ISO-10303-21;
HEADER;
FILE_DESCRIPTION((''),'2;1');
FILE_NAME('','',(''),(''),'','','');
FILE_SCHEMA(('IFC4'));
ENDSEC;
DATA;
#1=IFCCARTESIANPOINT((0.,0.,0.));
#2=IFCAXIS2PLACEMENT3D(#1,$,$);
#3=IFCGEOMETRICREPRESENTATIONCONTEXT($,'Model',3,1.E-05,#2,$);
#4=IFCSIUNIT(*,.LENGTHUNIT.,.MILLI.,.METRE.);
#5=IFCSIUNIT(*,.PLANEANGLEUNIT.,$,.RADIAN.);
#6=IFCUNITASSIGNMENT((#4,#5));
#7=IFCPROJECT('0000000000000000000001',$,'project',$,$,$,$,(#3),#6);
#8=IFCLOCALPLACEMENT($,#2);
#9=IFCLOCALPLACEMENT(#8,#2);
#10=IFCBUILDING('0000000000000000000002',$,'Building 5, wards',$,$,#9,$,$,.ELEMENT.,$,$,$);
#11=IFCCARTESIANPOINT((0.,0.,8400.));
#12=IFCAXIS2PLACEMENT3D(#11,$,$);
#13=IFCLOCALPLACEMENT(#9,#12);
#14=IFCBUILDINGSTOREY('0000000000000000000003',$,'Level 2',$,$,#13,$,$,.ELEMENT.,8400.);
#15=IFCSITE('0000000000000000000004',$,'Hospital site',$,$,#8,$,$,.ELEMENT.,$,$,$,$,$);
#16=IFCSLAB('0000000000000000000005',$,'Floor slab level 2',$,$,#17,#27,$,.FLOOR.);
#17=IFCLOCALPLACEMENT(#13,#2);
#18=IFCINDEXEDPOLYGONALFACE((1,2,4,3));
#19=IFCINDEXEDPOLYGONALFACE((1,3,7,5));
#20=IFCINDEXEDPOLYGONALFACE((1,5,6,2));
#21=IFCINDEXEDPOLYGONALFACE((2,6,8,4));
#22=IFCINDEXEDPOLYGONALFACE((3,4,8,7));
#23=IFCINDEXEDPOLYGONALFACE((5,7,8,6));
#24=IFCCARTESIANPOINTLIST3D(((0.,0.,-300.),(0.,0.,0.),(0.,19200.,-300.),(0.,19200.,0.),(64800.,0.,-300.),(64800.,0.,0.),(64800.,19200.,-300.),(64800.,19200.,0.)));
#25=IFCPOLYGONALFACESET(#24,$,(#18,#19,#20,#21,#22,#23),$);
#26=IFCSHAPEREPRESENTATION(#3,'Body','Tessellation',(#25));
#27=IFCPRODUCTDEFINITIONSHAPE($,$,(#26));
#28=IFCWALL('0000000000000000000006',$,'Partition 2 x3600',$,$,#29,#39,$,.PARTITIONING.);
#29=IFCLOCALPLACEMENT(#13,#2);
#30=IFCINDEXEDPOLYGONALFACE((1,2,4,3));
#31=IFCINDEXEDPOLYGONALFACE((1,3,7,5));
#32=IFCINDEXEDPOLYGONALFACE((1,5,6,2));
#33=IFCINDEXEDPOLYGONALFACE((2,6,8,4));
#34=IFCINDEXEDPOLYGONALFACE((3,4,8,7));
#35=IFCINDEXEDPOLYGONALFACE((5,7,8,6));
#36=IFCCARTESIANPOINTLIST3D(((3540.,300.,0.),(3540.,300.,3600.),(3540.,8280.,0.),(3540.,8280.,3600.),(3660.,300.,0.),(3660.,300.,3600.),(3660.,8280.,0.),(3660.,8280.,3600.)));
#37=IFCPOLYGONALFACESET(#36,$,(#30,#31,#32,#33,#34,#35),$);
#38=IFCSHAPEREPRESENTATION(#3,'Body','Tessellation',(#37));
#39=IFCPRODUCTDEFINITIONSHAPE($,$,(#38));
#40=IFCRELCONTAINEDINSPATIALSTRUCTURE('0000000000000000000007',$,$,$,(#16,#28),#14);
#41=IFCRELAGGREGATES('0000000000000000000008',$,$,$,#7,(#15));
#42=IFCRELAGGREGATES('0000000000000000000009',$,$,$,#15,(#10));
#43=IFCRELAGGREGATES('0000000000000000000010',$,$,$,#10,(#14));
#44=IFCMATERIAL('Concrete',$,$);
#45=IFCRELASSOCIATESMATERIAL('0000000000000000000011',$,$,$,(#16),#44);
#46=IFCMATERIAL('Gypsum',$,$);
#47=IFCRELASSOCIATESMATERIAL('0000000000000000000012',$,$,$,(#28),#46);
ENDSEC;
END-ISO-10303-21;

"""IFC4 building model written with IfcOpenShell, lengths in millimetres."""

from ifc_helpers import new_model, si_unit, frame, frame_2d, origin, place, context, project, spatial, rectangle, extrude, material, element, save


model = new_model("IFC4")

# Units and contexts
model_context = context("Model", 3, precision=1e-05, world=origin())
ifc_project = project(units=[si_unit("LENGTHUNIT", "METRE", prefix="MILLI"), si_unit("PLANEANGLEUNIT", "RADIAN")], contexts=[model_context])

# Site, building, storey
site_placement = place(None, origin())
site = spatial("IfcSite", under=ifc_project, at=site_placement, Name="Hospital site", CompositionType="ELEMENT")
building_placement = place(site_placement, origin())
building = spatial("IfcBuilding", under=site, at=building_placement, Name="Building 5, wards", CompositionType="ELEMENT")
storey_placement = place(building_placement, frame((0.0, 0.0, 8400.0)))
storey = spatial("IfcBuildingStorey", under=building, at=storey_placement, Name="Level 2", CompositionType="ELEMENT", Elevation=8400.0)

# Slab
ifc_material_1 = material(Name="Concrete")
slab_placement = place(storey_placement, origin())
element("IfcSlab", 1, at=slab_placement, inside=storey, material=ifc_material_1, Name="Floor slab level 2", PredefinedType="FLOOR", context=model_context, shape_type="SweptSolid", body=[
    extrude(rectangle(XDim=64800.0, YDim=19200.0, at=frame_2d((32400.0, 9600.0))), frame((0.0, 0.0, -300.0)), (0.0, 0.0, 1.0), 300.0),
])

# Wall
ifc_material_2 = material(Name="Gypsum")
wall_1_placement = place(storey_placement, frame((3660.0, 300.0, 0.0), x_axis=(0.0, 1.0, 0.0)))
element("IfcWall", 2, at=wall_1_placement, inside=storey, material=ifc_material_2, Name="Partition 2 x3600", PredefinedType="PARTITIONING", context=model_context, shape_type="SweptSolid", body=[
    extrude(rectangle(XDim=7980.0, YDim=120.0, at=frame_2d((3990.0, 60.0))), origin(), (0.0, 0.0, 1.0), 3600.0),
])

save(model, "model.ifc")
